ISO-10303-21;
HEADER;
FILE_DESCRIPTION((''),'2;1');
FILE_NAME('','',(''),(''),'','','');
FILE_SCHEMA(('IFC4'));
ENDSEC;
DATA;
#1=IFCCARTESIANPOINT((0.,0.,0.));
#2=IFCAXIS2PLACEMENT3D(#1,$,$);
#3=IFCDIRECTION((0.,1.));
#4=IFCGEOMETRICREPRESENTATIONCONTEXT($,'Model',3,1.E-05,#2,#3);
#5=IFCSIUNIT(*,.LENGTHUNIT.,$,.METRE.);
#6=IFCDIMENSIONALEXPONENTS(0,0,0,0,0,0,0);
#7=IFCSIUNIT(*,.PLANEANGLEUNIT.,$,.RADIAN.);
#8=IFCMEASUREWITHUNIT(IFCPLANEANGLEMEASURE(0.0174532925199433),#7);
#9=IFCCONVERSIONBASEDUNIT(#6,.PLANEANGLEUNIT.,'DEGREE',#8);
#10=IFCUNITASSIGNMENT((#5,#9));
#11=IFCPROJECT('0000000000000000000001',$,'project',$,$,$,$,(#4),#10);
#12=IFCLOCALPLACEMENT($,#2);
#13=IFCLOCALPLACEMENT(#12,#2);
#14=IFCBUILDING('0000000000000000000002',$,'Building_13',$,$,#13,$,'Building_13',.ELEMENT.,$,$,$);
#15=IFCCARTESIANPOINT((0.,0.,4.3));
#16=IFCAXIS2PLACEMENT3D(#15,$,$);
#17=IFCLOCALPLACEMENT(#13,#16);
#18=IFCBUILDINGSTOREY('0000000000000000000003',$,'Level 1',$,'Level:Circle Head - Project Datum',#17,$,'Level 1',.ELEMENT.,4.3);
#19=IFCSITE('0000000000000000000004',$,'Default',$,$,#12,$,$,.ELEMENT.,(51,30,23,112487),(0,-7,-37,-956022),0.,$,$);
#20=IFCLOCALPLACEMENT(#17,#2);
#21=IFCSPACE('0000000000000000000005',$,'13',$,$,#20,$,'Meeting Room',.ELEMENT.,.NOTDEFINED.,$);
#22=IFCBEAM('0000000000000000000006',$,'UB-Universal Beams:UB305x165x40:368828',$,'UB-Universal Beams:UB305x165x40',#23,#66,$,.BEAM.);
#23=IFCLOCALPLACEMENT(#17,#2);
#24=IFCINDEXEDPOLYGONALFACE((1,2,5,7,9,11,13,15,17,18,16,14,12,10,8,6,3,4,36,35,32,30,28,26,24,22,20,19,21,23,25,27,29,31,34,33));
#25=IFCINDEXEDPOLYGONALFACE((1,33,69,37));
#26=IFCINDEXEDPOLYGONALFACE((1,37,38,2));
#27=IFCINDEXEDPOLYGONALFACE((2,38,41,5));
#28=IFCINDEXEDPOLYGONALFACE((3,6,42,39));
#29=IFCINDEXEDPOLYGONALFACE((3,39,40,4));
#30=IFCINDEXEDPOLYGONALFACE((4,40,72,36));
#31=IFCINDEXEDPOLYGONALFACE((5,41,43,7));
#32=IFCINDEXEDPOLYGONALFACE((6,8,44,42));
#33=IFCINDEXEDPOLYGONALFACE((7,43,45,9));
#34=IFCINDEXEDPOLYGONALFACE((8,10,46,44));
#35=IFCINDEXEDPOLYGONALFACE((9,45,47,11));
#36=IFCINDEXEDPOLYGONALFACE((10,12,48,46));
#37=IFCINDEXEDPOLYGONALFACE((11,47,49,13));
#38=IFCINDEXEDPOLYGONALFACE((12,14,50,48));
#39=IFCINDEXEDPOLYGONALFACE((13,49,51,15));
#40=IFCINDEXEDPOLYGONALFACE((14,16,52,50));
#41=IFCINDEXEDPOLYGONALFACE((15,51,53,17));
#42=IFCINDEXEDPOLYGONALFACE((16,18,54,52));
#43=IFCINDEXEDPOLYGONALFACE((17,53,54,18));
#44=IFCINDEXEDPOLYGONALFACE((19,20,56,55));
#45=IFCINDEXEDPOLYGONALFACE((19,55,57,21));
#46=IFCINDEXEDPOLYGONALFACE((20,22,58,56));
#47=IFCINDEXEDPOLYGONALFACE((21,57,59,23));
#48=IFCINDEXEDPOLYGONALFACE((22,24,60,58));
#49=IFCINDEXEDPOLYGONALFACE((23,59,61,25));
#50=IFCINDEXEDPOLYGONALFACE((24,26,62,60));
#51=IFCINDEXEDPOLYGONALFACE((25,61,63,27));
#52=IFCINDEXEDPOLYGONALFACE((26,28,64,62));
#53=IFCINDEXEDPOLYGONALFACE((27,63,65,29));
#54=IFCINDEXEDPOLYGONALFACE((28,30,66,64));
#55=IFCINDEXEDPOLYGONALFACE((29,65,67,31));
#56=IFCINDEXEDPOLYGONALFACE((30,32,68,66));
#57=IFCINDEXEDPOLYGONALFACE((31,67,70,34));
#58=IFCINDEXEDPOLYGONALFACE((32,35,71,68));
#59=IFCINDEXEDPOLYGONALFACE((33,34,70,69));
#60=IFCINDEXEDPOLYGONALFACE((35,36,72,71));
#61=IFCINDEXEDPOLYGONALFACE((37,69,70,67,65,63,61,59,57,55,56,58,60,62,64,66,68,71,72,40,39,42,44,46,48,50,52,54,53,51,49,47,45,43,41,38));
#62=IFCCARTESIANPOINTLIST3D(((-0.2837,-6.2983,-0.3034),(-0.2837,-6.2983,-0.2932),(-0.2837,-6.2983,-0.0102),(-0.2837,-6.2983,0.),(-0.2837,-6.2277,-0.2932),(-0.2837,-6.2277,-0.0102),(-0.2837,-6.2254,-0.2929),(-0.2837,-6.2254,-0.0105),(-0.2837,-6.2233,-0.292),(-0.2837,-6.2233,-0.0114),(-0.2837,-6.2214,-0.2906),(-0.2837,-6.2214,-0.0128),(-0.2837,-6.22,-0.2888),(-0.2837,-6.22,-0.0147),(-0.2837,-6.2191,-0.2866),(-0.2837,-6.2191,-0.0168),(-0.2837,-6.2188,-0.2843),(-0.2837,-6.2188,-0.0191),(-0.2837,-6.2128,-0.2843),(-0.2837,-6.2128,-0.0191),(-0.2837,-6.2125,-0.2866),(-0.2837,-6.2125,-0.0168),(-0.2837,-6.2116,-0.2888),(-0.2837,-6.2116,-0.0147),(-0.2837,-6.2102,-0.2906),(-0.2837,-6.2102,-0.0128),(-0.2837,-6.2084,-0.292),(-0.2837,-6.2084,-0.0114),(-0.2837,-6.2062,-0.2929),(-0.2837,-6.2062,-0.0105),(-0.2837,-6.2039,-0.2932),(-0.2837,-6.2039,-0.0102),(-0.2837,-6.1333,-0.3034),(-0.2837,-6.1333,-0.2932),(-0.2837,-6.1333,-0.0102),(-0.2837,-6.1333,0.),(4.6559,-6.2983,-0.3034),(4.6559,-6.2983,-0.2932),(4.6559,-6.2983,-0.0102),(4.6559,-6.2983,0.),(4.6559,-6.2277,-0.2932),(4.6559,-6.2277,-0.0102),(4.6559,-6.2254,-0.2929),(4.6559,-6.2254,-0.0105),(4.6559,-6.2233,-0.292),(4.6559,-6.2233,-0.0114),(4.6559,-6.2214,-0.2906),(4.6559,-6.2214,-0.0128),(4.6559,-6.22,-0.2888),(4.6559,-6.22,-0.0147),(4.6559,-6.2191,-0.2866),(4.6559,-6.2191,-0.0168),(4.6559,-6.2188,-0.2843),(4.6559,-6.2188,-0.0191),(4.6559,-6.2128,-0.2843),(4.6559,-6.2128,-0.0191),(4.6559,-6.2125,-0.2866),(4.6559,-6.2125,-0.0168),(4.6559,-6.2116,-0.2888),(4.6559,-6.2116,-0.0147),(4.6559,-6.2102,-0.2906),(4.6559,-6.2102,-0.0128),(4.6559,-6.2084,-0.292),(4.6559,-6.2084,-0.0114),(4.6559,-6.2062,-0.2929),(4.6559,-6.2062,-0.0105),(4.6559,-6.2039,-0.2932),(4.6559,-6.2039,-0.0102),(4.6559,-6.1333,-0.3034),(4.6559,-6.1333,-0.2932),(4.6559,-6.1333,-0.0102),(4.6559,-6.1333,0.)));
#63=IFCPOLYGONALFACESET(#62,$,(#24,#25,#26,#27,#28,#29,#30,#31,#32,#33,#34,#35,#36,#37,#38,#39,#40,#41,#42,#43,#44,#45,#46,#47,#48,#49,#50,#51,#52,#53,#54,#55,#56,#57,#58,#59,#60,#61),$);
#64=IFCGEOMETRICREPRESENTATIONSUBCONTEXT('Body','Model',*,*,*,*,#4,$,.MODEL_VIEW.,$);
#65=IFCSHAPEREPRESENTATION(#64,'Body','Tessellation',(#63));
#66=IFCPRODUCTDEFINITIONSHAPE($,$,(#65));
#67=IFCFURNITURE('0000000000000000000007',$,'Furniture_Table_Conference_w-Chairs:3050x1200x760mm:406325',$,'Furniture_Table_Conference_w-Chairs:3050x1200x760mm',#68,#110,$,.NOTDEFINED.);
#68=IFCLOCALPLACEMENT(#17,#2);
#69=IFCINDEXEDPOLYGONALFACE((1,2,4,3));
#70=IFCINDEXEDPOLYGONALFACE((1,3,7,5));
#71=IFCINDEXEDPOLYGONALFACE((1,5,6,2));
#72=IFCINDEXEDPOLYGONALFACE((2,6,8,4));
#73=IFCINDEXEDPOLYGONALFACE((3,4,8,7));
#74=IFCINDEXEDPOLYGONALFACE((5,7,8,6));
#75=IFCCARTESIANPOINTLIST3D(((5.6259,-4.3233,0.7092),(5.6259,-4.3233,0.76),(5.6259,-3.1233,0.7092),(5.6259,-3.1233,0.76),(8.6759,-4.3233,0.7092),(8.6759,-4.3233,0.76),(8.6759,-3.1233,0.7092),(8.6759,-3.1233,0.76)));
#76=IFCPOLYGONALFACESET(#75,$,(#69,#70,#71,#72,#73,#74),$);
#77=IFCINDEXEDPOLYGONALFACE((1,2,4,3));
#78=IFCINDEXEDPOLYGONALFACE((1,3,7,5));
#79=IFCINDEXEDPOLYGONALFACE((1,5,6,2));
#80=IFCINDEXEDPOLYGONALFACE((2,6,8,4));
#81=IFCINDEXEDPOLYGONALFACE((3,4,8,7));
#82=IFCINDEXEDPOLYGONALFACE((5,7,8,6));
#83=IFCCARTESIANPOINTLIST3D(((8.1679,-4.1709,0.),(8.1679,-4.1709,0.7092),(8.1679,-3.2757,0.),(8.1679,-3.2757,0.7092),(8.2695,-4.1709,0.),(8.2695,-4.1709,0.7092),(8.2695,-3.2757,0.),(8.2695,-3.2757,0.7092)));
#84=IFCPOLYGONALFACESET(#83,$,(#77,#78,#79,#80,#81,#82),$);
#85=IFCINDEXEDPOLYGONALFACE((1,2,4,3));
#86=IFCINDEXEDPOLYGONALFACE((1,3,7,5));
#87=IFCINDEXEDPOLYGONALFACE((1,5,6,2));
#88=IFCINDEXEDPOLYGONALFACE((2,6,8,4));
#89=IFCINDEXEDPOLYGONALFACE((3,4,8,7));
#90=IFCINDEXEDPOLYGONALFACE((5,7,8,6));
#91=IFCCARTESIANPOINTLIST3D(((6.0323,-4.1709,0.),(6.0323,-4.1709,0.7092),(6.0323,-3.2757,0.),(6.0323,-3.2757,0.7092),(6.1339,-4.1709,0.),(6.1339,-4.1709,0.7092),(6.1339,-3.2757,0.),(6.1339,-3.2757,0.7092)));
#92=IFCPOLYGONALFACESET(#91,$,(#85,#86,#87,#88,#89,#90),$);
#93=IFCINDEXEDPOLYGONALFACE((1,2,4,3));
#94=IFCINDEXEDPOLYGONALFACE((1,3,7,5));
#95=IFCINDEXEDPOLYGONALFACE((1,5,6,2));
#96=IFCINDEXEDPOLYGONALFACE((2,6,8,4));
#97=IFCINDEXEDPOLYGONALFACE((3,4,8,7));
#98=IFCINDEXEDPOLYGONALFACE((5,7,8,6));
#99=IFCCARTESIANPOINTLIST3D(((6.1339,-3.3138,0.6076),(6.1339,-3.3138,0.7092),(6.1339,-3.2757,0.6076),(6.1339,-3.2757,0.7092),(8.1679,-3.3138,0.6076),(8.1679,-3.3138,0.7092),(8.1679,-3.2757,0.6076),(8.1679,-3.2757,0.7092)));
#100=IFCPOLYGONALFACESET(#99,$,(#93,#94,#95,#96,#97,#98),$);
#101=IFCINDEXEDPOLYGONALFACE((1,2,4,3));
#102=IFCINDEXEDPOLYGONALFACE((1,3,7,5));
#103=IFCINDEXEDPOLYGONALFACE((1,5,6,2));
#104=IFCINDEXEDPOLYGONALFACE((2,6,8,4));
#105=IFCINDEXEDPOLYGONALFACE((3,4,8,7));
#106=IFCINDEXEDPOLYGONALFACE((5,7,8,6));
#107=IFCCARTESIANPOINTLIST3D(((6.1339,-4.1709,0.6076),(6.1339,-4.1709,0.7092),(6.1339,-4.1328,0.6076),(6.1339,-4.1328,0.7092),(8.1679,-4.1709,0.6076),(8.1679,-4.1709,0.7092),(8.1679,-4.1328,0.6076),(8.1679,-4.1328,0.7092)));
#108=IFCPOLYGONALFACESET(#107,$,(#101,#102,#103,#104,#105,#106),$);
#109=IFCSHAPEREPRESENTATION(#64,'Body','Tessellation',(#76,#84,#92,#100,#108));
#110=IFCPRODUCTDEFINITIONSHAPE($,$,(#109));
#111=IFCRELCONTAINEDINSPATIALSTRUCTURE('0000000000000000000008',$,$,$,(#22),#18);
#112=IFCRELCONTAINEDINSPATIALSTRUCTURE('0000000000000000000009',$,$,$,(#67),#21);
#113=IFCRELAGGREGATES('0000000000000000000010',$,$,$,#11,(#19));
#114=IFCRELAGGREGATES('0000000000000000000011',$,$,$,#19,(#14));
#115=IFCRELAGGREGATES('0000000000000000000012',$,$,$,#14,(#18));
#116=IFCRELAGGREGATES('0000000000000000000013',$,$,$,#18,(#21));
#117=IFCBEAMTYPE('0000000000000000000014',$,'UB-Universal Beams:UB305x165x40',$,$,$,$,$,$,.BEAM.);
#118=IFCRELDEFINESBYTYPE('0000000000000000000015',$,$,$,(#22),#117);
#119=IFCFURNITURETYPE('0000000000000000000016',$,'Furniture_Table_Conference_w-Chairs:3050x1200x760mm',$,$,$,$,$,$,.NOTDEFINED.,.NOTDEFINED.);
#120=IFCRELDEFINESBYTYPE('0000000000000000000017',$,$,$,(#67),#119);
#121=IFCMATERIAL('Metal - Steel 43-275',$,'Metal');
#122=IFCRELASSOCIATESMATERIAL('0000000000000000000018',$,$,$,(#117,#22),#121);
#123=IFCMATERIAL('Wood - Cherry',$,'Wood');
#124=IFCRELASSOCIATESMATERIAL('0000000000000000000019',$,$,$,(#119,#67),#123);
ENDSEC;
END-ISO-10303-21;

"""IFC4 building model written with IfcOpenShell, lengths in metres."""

from ifc_helpers import new_model, entity, si_unit, converted_unit, direction, frame, origin, place, context, subcontext, project, spatial, line, arc, indexed_curve, outline, extrude, source, transform, mapped, material, type_object, type_shapes, element, save


model = new_model("IFC4")

# Units and contexts
model_context = context("Model", 3, precision=1e-05, world=origin(), true_north=direction((0.0, 1.0)))
body_context = subcontext(model_context, "Body", "Model", "MODEL_VIEW")
ifc_project = project(units=[si_unit("LENGTHUNIT", "METRE"), converted_unit("PLANEANGLEUNIT", "DEGREE", entity("IfcPlaneAngleMeasure", 0.0174532925199433), si_unit("PLANEANGLEUNIT", "RADIAN"), dimensions=[0, 0, 0, 0, 0, 0, 0])], contexts=[model_context])

# Site, building, storey
site_placement = place(None, origin())
site = spatial("IfcSite", under=ifc_project, at=site_placement, Name="Default", CompositionType="ELEMENT", RefLatitude=(51, 30, 23, 112487), RefLongitude=(0, -7, -37, -956022), RefElevation=0.0)
building_placement = place(site_placement, origin())
building = spatial("IfcBuilding", under=site, at=building_placement, Name="Building_13", LongName="Building_13", CompositionType="ELEMENT")
storey_placement = place(building_placement, frame((0.0, 0.0, 4.3)))
storey = spatial("IfcBuildingStorey", under=building, at=storey_placement, Name="Level 1", ObjectType="Level:Circle Head - Project Datum", LongName="Level 1", CompositionType="ELEMENT", Elevation=4.3)

# Beam
ifc_material_1 = material(Name="Metal - Steel 43-275", Category="Metal")
beam_type_1 = type_object("IfcBeamType", Name="UB-Universal Beams:UB305x165x40", PredefinedType="BEAM", material=ifc_material_1)
shared_shape_1 = source(origin(), body_context, "Body", "SweptSolid", [
    extrude(outline(indexed_curve([(-0.0825, -0.1415), (-0.0825, -0.1517), (0.0825, -0.1517), (0.0825, -0.1415), (0.0119, -0.1415), (0.0056, -0.1389), (0.003, -0.1326), (0.003, 0.1326), (0.0056, 0.1389), (0.0119, 0.1415), (0.0825, 0.1415), (0.0825, 0.1517), (-0.0825, 0.1517), (-0.0825, 0.1415), (-0.0119, 0.1415), (-0.0056, 0.1389), (-0.003, 0.1326), (-0.003, -0.1326), (-0.0056, -0.1389), (-0.0119, -0.1415)], segments=[line(1, 2, 3, 4, 5), arc(5, 6, 7), line(7, 8), arc(8, 9, 10), line(10, 11, 12, 13, 14, 15), arc(15, 16, 17), line(17, 18), arc(18, 19, 20), line(20, 1)], self_intersect=False)), frame((-2.3846, 0.0, 0.0), z_axis=(-1.0, 0.0, 0.0), x_axis=(0.0, -1.0, 0.0)), (0.0, 0.0, -1.0), 4.9396),
])
type_shapes(beam_type_1, [shared_shape_1])
beam_1_placement = place(storey_placement, frame((2.1009, -6.2158, -0.1517)))
element("IfcBeam", 1, at=beam_1_placement, inside=storey, type_object=beam_type_1, material=ifc_material_1, Name="UB-Universal Beams:UB305x165x40:368828", ObjectType="UB-Universal Beams:UB305x165x40", PredefinedType="BEAM", context=body_context, shape_type="MappedRepresentation", body=[
    mapped(shared_shape_1, transform((0.0, 0.0, 0.0), scale=1.0)),
])

# Shared definitions
space_placement = place(storey_placement, origin())
space = spatial("IfcSpace", under=storey, at=space_placement, Name="13", LongName="Meeting Room", CompositionType="ELEMENT", PredefinedType="NOTDEFINED")

# Furniture
ifc_material_2 = material(Name="Wood - Cherry", Category="Wood")
furniture_type_1 = type_object("IfcFurnitureType", Name="Furniture_Table_Conference_w-Chairs:3050x1200x760mm", AssemblyPlace="NOTDEFINED", PredefinedType="NOTDEFINED", material=ifc_material_2)
shared_shape_2 = source(origin(), body_context, "Body", "SweptSolid", [
    extrude(outline(indexed_curve([(-0.6, -1.525), (0.6, -1.525), (0.6, 1.525), (-0.6, 1.525), (-0.6, -1.525)], self_intersect=False)), frame((0.0, 0.0, 0.7092), z_axis=(0.0, 0.0, 1.0), x_axis=(0.0, 1.0, 0.0)), (0.0, 0.0, 1.0), 0.0508),
    extrude(outline(indexed_curve([(-0.4476, -0.0508), (0.4476, -0.0508), (0.4476, 0.0508), (-0.4476, 0.0508), (-0.4476, -0.0508)], self_intersect=False)), frame((1.0678, 0.0, 0.0), z_axis=(0.0, 0.0, 1.0), x_axis=(0.0, 1.0, 0.0)), (0.0, 0.0, 1.0), 0.7092),
    extrude(outline(indexed_curve([(-0.4476, -0.0508), (0.4476, -0.0508), (0.4476, 0.0508), (-0.4476, 0.0508), (-0.4476, -0.0508)], self_intersect=False)), frame((-1.0678, 0.0, 0.0), z_axis=(0.0, 0.0, 1.0), x_axis=(0.0, 1.0, 0.0)), (0.0, 0.0, 1.0), 0.7092),
    extrude(outline(indexed_curve([(-1.017, -0.0191), (1.017, -0.0191), (1.017, 0.0191), (-1.017, 0.0191), (-1.017, -0.0191)], self_intersect=False)), frame((0.0, 0.4286, 0.6076), z_axis=(0.0, 0.0, 1.0), x_axis=(-1.0, 0.0, 0.0)), (0.0, 0.0, 1.0), 0.1016),
    extrude(outline(indexed_curve([(-0.019, -1.017), (0.019, -1.017), (0.019, 1.017), (-0.019, 1.017), (-0.019, -1.017)], self_intersect=False)), frame((0.0, -0.4286, 0.6076), z_axis=(0.0, 0.0, 1.0), x_axis=(0.0, 1.0, 0.0)), (0.0, 0.0, 1.0), 0.1016),
])
type_shapes(furniture_type_1, [shared_shape_2])
furniture_1_placement = place(space_placement, frame((7.1509, -3.7233, 0.0)))
element("IfcFurniture", 2, at=furniture_1_placement, inside=space, type_object=furniture_type_1, material=ifc_material_2, Name="Furniture_Table_Conference_w-Chairs:3050x1200x760mm:406325", ObjectType="Furniture_Table_Conference_w-Chairs:3050x1200x760mm", PredefinedType="NOTDEFINED", context=body_context, shape_type="MappedRepresentation", body=[
    mapped(shared_shape_2, transform((0.0, 0.0, 0.0), scale=1.0)),
])

save(model, "model.ifc")
